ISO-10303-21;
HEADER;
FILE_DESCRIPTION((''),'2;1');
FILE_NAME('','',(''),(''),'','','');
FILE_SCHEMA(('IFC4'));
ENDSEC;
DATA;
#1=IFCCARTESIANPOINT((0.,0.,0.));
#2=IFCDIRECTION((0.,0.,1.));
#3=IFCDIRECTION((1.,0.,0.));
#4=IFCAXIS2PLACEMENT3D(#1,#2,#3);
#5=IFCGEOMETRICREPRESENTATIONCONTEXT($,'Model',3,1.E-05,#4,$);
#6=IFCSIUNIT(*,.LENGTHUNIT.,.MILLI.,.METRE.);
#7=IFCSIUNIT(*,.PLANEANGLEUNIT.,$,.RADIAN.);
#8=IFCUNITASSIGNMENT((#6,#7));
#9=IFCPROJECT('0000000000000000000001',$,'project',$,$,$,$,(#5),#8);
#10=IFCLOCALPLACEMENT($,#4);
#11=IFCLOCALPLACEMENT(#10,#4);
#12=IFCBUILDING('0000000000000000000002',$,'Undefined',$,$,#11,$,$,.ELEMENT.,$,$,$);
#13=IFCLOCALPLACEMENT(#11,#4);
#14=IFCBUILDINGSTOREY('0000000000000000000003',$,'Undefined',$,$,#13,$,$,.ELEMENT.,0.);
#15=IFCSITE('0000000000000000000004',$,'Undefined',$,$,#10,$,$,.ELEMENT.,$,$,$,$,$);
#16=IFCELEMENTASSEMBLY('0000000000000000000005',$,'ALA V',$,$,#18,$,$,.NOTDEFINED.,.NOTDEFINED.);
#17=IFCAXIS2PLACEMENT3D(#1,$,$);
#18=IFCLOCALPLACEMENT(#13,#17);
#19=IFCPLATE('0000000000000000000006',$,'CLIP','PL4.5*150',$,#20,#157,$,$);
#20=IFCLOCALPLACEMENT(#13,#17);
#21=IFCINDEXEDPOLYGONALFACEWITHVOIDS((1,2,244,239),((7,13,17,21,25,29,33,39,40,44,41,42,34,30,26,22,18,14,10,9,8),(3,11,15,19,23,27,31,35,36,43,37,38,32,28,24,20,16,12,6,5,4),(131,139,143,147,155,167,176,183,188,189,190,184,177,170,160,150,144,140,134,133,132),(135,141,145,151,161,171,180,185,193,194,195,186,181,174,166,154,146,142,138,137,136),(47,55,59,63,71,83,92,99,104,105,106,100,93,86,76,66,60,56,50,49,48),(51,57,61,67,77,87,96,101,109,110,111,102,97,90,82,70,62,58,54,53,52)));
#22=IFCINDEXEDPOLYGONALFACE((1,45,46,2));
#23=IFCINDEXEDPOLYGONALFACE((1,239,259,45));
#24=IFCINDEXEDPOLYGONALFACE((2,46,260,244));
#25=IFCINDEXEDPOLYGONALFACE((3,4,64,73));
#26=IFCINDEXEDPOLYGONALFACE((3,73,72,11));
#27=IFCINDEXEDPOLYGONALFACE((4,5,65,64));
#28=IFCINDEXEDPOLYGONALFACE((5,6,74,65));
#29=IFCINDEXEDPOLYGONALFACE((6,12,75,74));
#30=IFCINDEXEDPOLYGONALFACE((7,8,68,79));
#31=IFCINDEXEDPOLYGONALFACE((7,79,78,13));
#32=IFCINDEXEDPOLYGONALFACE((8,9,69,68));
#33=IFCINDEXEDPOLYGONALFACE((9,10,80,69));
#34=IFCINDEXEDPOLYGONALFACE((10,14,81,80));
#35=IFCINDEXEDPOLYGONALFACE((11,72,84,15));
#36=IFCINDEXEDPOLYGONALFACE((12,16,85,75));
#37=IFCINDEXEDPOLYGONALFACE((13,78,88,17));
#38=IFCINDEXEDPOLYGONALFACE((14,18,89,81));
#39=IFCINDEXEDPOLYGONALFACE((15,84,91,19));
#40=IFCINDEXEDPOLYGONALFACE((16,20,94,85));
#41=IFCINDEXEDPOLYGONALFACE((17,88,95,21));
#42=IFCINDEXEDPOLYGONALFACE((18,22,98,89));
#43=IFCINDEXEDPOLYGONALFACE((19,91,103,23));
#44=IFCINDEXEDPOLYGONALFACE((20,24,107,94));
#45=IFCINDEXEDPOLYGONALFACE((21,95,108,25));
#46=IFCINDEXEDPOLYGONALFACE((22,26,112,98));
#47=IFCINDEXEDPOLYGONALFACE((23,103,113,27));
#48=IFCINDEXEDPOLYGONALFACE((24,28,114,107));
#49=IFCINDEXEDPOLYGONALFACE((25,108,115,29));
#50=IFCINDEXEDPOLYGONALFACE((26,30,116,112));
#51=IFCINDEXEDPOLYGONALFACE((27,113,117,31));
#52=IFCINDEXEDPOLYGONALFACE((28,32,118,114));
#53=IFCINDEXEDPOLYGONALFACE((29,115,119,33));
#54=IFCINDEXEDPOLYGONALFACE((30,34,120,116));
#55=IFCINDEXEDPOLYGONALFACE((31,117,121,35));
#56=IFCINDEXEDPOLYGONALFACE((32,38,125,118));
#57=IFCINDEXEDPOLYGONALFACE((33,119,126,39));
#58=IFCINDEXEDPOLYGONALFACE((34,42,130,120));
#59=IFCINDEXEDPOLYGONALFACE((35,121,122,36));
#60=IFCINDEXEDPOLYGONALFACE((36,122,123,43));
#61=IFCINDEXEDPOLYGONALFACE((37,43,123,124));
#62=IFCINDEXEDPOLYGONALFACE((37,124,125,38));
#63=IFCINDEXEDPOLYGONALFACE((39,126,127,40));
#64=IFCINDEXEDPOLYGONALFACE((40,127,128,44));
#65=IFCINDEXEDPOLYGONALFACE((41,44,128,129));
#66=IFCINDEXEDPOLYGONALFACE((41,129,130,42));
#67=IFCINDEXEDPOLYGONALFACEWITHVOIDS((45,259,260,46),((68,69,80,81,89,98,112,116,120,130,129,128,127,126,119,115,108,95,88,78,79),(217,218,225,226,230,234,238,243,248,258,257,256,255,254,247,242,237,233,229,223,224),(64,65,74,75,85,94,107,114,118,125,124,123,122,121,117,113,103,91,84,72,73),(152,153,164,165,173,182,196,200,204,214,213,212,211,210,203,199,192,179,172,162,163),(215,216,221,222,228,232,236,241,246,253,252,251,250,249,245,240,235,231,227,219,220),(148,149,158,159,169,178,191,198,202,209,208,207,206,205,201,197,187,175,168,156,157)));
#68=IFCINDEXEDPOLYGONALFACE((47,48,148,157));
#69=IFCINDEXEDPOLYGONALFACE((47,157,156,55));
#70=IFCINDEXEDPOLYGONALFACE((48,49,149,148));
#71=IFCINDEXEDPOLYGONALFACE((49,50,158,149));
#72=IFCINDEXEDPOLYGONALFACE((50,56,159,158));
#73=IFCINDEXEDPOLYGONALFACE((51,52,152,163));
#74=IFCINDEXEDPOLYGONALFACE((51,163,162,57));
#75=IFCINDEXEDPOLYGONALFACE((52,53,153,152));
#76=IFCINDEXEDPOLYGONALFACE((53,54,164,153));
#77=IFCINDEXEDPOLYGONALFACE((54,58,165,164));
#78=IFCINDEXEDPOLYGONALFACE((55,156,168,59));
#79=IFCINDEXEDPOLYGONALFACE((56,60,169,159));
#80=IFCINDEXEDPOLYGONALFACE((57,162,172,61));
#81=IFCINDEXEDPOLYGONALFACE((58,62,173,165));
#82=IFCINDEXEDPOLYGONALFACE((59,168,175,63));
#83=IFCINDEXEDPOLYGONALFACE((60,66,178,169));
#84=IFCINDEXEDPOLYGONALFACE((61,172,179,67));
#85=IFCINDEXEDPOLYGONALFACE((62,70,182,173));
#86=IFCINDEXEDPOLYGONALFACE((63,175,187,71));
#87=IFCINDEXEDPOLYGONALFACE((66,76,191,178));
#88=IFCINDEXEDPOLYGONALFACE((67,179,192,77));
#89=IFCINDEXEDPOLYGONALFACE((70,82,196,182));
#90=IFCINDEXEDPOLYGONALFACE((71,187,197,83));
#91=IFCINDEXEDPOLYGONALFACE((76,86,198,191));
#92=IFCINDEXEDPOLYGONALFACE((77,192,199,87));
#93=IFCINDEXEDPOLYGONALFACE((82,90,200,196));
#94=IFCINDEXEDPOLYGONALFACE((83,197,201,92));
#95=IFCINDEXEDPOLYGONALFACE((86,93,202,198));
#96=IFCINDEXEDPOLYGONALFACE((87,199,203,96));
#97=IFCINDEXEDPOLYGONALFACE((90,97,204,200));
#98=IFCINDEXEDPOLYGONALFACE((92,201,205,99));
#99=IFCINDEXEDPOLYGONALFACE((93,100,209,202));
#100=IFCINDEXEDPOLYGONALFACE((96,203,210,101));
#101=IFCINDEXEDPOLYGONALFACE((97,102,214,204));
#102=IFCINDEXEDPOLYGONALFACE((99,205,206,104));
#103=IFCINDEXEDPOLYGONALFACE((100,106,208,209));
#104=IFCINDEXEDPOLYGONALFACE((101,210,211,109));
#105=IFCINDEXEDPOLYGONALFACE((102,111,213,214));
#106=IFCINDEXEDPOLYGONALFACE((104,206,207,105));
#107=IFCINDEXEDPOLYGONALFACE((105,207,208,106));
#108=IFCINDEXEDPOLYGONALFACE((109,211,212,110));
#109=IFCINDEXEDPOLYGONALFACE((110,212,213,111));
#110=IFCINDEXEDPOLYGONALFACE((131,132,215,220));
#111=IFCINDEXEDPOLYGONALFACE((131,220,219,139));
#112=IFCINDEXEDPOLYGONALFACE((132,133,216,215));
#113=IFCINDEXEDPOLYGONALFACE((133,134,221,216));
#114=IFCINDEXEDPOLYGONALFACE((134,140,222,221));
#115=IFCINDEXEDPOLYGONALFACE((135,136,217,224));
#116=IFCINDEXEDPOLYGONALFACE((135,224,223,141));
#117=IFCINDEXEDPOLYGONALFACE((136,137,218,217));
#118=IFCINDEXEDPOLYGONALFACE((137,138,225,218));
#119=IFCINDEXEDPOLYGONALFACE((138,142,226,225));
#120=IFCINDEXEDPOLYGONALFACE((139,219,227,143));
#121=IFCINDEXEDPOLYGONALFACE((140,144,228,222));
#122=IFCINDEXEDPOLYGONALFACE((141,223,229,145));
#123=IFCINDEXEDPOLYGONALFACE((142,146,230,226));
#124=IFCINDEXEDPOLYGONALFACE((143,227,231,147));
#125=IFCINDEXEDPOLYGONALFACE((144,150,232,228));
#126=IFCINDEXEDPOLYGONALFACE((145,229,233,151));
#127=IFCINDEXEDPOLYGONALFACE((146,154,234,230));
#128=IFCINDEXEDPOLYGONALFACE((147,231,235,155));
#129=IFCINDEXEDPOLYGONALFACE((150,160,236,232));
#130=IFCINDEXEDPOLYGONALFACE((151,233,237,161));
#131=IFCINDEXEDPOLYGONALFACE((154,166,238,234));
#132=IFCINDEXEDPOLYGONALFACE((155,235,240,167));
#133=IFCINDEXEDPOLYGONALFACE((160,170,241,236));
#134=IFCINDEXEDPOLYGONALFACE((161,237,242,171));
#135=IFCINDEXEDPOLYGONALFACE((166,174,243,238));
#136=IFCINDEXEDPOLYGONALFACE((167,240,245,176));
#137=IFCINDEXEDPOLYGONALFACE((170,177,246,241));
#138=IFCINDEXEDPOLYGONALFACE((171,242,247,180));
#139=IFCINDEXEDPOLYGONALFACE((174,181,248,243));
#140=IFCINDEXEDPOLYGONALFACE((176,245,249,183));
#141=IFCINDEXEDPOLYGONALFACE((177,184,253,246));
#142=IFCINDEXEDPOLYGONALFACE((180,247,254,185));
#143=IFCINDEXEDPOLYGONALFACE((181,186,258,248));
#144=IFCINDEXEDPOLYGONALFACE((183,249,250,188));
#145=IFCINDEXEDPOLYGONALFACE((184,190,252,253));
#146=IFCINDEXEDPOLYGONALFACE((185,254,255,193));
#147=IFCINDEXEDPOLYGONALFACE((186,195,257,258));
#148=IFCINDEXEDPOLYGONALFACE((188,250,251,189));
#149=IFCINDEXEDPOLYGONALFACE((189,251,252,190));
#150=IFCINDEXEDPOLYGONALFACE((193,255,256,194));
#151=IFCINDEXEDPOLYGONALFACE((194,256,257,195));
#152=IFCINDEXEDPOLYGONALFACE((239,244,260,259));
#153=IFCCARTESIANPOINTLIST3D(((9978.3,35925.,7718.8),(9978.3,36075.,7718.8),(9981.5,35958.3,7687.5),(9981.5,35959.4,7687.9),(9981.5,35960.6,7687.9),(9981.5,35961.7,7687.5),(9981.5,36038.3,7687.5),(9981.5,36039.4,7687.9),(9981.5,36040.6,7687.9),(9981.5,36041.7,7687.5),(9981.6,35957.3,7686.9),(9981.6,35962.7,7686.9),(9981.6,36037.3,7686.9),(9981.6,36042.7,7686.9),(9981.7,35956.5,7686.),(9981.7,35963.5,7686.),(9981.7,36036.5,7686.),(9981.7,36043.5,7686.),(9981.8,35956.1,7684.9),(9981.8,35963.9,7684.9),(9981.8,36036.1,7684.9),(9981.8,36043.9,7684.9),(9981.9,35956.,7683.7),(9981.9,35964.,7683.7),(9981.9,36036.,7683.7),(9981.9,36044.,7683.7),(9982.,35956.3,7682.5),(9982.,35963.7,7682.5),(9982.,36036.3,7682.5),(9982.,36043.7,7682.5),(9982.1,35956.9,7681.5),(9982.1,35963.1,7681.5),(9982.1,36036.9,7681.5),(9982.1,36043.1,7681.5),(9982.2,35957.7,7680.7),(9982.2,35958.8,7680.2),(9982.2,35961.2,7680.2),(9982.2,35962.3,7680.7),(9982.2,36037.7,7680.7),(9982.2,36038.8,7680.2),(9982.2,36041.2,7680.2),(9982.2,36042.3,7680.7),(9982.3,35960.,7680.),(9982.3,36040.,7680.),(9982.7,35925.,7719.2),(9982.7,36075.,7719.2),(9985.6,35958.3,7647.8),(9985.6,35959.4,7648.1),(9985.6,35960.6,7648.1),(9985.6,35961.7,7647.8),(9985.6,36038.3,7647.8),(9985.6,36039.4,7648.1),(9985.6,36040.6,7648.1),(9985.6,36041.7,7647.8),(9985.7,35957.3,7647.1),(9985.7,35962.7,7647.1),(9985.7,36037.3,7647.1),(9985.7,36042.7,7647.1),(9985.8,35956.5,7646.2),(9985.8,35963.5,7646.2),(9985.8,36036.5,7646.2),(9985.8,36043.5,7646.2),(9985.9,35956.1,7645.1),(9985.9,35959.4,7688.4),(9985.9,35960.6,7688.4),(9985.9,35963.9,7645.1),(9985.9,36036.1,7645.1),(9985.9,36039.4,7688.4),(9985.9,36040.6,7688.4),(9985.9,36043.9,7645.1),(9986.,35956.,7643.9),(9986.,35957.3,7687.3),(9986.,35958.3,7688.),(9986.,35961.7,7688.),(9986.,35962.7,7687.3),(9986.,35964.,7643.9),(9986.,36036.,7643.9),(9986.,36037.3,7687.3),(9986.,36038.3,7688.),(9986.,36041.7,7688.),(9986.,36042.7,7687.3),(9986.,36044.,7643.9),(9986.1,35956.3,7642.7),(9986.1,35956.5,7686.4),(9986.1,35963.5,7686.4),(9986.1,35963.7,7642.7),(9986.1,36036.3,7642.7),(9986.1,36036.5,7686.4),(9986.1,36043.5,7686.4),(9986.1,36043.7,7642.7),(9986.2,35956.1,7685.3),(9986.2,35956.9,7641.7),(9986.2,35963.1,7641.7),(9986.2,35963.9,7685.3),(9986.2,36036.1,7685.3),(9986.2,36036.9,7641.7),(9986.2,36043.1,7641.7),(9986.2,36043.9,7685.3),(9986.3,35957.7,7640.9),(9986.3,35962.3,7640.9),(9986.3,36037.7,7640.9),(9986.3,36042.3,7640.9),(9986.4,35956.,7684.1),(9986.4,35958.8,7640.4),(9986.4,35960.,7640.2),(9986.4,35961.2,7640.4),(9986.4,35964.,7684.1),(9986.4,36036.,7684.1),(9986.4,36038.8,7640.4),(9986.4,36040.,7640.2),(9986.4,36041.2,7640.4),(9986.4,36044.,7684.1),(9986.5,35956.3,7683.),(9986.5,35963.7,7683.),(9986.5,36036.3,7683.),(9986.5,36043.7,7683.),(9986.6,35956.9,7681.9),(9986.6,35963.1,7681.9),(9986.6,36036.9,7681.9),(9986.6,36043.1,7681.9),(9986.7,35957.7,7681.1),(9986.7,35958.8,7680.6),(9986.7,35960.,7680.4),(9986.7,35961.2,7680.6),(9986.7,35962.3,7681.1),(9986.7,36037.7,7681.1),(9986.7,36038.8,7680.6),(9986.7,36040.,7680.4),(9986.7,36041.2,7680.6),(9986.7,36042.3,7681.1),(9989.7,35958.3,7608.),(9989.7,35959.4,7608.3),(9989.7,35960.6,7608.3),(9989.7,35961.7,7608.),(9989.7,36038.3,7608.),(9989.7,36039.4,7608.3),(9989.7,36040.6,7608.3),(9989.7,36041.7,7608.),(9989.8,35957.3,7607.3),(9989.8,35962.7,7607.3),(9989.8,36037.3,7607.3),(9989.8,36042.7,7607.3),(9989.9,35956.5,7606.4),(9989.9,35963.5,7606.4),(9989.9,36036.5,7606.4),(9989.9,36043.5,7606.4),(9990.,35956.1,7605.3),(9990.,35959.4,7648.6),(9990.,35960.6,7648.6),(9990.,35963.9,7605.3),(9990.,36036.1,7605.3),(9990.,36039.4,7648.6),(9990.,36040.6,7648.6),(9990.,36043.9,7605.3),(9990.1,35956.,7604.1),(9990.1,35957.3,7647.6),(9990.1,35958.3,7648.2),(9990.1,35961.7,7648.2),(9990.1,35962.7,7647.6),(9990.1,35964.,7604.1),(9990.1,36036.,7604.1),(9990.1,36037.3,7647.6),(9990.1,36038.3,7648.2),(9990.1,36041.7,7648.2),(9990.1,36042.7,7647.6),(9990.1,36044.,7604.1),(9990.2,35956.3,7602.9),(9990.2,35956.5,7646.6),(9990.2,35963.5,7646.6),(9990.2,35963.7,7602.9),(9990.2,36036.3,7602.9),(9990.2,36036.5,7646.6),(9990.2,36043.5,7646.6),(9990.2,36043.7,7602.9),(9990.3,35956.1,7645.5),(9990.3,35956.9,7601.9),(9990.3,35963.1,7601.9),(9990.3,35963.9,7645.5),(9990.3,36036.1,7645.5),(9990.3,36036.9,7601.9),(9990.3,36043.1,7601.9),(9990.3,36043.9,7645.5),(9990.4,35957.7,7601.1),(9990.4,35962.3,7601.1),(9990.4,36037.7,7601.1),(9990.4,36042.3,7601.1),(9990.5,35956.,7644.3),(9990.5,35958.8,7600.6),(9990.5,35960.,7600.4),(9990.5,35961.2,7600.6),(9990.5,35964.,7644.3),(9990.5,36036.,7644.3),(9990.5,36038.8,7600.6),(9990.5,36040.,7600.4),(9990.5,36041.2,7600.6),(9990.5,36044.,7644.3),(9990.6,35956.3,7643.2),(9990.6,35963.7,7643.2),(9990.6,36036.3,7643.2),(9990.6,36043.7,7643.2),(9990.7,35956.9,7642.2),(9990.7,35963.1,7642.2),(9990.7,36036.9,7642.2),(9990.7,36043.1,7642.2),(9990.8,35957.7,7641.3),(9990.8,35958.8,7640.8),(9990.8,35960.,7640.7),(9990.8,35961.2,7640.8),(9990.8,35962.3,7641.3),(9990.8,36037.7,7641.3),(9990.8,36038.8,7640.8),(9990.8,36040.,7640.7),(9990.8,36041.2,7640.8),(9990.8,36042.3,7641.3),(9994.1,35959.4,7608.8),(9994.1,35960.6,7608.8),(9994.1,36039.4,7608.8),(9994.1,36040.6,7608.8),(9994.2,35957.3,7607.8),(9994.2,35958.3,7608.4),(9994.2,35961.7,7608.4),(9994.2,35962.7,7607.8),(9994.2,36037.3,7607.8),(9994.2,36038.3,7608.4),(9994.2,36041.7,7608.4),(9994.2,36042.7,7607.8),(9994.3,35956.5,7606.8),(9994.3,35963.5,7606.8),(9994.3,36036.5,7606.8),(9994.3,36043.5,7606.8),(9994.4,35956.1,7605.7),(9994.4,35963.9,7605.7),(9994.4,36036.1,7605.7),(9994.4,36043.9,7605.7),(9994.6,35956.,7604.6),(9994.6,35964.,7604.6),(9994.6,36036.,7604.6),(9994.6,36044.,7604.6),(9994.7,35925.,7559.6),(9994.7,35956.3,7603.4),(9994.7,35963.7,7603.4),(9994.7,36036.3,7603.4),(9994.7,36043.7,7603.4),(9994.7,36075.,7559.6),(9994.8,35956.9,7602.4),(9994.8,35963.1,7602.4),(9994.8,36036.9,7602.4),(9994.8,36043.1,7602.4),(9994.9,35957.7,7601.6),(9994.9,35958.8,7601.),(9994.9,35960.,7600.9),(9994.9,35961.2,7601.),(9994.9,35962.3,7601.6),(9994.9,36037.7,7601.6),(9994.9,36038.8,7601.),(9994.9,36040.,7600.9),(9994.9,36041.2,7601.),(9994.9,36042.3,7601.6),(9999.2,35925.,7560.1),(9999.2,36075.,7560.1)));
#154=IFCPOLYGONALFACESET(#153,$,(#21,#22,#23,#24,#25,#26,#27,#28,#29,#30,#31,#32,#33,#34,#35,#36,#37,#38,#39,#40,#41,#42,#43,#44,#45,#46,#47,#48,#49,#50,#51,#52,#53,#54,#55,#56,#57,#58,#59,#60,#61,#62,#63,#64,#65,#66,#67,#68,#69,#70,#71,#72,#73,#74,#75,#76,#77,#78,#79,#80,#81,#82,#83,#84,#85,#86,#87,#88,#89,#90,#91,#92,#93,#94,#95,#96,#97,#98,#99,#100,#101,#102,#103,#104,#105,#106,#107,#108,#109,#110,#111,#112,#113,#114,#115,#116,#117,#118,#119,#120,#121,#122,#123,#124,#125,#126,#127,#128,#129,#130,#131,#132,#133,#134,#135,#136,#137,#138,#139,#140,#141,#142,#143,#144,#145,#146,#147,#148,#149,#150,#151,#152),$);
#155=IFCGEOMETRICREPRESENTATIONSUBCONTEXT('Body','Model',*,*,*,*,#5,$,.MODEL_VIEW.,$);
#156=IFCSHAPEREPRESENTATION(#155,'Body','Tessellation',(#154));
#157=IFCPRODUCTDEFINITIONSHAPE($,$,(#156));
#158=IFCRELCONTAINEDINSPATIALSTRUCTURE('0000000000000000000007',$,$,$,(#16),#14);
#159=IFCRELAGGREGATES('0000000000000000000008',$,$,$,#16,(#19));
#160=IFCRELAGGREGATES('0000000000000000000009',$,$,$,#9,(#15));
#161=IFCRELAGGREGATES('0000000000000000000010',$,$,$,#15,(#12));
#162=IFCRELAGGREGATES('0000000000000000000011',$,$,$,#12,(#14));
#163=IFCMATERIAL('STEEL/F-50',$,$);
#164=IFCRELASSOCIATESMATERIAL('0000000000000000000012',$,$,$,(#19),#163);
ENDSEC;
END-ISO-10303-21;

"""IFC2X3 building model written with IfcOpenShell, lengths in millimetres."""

from ifc_helpers import new_model, si_unit, frame, origin_with_axes, origin_2d_with_axis, place, context, subcontext, project, spatial, polyline, circle, outline, extrude, source, transform, mapped, material, element, aggregate, save


model = new_model("IFC2X3")

# Units and contexts
model_context = context("Model", 3, precision=1e-05, world=origin_with_axes())
body_context = subcontext(model_context, "Body", "Model", "MODEL_VIEW")
ifc_project = project(units=[si_unit("LENGTHUNIT", "METRE", prefix="MILLI"), si_unit("PLANEANGLEUNIT", "RADIAN")], contexts=[model_context])

# Site, building, storey
site_placement = place(None, origin_with_axes())
site = spatial("IfcSite", under=ifc_project, at=site_placement, Name="Undefined", CompositionType="ELEMENT")
building_placement = place(site_placement, origin_with_axes())
building = spatial("IfcBuilding", under=site, at=building_placement, Name="Undefined", CompositionType="ELEMENT")
storey_placement = place(building_placement, origin_with_axes())
storey = spatial("IfcBuildingStorey", under=building, at=storey_placement, Name="Undefined", CompositionType="ELEMENT", Elevation=0.0)

# Element assembly
assembly_1_placement = place(storey_placement, origin_with_axes())
assembly_1 = element("IfcElementAssembly", 1, at=assembly_1_placement, inside=storey, Name="ALA V", AssemblyPlace="NOTDEFINED", PredefinedType="NOTDEFINED")
ifc_material_1 = material(Name="STEEL/F-50")

# Plate, openings
plate_1_placement = place(assembly_1_placement, frame((9980.5, 35925.0, 7719.0), z_axis=(0.994727, 0.0, 0.102562), x_axis=(0.102562, 0.0, -0.994727)))
plate_1 = element("IfcPlate", 2, at=plate_1_placement, material=ifc_material_1, Name="CLIP", Description="PL4.5*150", context=body_context, shape_type="SweptSolid", body=[
    extrude(outline(polyline([(0.0, 0.0), (160.0, 0.0), (160.0, 150.0), (0.0, 150.0), (0.0, 0.0)])), frame((0.0, 0.0, -2.2), z_axis=(0.0, 0.0, 1.0), x_axis=(1.0, 0.0, 0.0)), (0.0, 0.0, 1.0), 4.5),
])
shared_shape_1 = source(origin_with_axes(), body_context, "Body", "SweptSolid", [
    extrude(circle(Radius=4.0, at=origin_2d_with_axis()), frame((0.0, -4.6, 0.0), z_axis=(0.0, 1.0, 0.0), x_axis=(1.0, 0.0, 0.0)), (0.0, 0.0, 1.0), 4.7),
])
opening_1_placement = place(assembly_1_placement, frame((9981.9, 36040.0, 7684.0), z_axis=(0.0, 1.0, 0.0), x_axis=(0.102562, 0.0, -0.994727)))
element("IfcOpeningElement", 3, at=opening_1_placement, cuts=plate_1, ObjectType="Opening", context=body_context, shape_type="MappedRepresentation", body=[
    mapped(shared_shape_1, transform((0.0, 0.0, 0.0))),
    mapped(shared_shape_1, transform((40.0, 0.0, 0.0))),
    mapped(shared_shape_1, transform((80.0, 0.0, 0.0))),
])
opening_2_placement = place(assembly_1_placement, frame((9981.9, 35960.0, 7684.0), z_axis=(0.0, 1.0, 0.0), x_axis=(0.102562, 0.0, -0.994727)))
element("IfcOpeningElement", 4, at=opening_2_placement, cuts=plate_1, ObjectType="Opening", context=body_context, shape_type="MappedRepresentation", body=[
    mapped(shared_shape_1, transform((0.0, 0.0, 0.0))),
    mapped(shared_shape_1, transform((40.0, 0.0, 0.0))),
    mapped(shared_shape_1, transform((80.0, 0.0, 0.0))),
])

aggregate(assembly_1, [plate_1])

save(model, "model.ifc")
